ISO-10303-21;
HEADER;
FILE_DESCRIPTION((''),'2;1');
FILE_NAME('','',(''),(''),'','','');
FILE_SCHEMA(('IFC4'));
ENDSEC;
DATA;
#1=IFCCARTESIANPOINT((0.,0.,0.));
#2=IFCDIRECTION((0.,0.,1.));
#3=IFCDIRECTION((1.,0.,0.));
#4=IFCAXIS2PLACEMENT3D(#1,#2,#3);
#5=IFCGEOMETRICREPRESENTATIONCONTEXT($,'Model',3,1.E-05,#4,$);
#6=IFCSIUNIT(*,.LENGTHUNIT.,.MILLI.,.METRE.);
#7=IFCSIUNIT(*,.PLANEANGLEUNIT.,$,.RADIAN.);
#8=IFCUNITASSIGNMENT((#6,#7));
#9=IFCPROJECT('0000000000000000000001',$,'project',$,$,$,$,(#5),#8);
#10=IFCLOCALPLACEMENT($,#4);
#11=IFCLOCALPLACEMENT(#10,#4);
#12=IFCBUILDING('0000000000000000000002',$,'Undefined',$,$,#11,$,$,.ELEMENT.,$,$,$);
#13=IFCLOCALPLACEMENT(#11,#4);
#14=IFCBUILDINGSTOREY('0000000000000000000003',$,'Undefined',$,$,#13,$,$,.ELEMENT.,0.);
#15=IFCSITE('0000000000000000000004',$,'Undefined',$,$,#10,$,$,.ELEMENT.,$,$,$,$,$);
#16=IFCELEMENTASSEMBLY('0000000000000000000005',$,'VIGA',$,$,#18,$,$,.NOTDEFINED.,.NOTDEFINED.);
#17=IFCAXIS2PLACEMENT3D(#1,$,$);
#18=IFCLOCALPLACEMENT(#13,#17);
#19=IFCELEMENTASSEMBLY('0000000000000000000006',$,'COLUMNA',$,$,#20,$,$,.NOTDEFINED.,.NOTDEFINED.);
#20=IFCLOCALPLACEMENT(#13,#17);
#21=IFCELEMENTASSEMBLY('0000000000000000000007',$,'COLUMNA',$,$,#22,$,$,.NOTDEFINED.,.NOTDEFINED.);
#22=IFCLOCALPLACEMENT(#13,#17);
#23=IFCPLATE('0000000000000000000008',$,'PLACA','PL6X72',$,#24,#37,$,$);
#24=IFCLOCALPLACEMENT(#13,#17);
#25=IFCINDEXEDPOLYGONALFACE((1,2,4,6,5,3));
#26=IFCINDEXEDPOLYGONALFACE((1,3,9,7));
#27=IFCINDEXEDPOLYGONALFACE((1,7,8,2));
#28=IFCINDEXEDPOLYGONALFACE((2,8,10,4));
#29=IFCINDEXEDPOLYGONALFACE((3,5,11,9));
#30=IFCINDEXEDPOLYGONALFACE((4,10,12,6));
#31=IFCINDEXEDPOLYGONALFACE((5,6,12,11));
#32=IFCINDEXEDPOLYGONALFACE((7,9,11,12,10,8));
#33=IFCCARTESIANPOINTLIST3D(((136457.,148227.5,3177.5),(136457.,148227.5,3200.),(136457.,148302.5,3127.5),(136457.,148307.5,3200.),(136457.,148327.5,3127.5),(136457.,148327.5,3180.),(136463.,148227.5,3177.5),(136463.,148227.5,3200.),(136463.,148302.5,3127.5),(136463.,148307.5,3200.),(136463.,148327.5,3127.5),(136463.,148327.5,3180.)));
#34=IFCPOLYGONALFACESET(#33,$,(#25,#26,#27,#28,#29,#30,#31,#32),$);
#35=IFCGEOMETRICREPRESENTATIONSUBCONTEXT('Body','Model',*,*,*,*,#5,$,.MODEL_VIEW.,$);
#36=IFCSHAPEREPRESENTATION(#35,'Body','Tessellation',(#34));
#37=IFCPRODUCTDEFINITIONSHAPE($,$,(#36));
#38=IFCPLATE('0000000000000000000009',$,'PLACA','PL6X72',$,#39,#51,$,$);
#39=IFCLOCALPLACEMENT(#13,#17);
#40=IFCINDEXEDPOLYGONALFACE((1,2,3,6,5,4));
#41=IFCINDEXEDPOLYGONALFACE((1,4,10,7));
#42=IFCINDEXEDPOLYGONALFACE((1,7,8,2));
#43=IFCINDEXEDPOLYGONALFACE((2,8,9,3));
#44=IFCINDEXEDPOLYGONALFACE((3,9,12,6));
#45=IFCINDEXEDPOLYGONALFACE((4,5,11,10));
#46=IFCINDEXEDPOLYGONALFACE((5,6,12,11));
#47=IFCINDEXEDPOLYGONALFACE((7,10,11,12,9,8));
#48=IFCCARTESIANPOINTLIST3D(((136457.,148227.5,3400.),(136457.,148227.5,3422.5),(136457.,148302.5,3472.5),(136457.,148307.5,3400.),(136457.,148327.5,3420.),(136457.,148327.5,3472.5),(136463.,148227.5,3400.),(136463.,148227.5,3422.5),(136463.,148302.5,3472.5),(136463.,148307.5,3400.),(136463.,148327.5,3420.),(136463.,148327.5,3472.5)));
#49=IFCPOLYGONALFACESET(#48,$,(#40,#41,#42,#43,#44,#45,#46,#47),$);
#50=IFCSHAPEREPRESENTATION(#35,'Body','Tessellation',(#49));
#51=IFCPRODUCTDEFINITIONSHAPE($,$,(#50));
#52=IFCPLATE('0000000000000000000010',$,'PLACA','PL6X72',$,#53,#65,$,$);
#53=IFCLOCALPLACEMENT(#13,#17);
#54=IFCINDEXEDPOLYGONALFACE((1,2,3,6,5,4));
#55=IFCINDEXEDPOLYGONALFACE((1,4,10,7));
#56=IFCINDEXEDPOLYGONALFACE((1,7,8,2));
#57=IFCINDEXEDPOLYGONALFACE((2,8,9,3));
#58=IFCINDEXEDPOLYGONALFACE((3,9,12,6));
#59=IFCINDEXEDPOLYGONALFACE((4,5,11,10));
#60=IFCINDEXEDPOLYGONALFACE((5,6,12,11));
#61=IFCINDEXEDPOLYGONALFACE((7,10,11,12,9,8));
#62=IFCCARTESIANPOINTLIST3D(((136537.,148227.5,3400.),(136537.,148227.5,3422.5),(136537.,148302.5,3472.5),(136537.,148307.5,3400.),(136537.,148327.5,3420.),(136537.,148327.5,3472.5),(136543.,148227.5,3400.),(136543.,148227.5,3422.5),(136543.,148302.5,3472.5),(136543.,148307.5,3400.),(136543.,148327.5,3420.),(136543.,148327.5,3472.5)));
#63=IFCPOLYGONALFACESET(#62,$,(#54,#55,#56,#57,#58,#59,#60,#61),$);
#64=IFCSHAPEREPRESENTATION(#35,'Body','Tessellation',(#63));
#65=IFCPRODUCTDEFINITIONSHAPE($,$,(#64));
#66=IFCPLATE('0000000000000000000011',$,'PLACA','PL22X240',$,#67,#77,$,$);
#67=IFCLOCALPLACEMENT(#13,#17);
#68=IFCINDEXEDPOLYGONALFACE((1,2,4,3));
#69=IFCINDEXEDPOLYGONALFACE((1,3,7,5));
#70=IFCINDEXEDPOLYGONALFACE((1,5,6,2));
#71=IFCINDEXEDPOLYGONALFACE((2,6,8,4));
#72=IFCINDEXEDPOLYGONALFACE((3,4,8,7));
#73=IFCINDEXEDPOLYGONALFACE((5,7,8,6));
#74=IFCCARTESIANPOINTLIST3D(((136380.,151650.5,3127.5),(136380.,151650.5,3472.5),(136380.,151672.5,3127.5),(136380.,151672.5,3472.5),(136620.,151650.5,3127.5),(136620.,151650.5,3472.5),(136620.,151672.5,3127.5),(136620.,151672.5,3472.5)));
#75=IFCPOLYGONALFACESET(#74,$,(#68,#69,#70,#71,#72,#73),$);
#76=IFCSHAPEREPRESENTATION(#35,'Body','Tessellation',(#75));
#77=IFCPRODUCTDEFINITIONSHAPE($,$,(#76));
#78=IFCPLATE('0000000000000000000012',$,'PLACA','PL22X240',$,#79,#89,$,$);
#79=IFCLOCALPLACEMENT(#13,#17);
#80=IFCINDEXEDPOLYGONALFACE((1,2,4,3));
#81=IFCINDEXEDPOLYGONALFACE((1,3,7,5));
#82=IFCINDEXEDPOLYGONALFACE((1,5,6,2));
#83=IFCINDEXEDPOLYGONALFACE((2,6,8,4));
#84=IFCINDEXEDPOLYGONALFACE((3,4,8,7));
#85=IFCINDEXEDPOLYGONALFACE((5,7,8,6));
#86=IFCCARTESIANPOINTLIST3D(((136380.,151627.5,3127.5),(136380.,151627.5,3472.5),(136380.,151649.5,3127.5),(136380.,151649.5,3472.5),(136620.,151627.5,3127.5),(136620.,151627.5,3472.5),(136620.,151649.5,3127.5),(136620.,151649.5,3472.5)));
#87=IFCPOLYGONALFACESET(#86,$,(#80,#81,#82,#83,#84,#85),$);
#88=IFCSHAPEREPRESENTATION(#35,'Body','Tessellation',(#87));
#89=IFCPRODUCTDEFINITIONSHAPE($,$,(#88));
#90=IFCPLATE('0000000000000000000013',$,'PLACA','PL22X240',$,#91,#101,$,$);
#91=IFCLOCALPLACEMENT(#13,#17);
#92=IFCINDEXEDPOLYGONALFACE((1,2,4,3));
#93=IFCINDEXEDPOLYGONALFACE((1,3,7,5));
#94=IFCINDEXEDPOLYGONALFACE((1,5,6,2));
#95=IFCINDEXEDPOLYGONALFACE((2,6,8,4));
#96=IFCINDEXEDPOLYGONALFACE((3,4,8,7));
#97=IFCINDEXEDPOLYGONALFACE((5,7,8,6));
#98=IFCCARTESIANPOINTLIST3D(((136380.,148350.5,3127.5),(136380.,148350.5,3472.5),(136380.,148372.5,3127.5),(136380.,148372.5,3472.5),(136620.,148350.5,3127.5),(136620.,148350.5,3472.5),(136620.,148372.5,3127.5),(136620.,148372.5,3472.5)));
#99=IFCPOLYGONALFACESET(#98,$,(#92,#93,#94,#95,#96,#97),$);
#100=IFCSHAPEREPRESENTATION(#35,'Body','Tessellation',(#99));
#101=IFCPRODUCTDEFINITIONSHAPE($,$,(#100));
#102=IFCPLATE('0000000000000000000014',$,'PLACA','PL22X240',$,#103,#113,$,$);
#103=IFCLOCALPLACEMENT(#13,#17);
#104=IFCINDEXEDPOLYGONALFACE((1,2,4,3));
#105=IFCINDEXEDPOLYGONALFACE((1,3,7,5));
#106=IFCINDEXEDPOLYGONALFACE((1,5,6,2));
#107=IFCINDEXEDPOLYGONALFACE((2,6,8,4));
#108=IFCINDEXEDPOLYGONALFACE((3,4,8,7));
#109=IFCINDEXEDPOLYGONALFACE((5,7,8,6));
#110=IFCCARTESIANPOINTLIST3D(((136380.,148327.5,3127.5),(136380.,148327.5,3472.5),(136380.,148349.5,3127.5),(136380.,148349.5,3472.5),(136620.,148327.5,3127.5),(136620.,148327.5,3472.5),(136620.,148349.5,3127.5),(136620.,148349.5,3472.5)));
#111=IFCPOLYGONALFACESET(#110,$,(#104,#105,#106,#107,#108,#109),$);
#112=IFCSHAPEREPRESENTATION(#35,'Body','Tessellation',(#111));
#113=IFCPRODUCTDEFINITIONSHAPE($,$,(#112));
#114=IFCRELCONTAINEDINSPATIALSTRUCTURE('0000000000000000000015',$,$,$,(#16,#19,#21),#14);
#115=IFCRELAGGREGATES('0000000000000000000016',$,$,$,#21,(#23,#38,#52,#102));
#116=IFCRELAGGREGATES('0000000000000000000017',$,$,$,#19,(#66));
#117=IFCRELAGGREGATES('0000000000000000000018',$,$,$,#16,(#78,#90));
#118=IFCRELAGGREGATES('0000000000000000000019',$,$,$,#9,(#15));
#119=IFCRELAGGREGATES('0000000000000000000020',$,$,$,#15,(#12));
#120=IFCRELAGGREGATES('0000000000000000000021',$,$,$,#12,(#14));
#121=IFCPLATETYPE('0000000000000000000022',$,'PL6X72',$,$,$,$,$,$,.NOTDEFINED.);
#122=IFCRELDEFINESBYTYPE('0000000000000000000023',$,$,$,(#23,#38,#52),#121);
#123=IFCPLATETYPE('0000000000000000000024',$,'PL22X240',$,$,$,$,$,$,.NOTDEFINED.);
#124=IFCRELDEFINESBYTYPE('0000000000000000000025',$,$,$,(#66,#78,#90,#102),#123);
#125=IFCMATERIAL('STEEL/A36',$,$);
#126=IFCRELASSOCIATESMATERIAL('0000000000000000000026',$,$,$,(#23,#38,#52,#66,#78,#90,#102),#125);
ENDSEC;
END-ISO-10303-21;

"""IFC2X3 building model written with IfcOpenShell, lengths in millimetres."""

from ifc_helpers import new_model, si_unit, frame, origin_with_axes, place, context, subcontext, project, spatial, polyline, outline, extrude, material, type_object, element, aggregate, save


model = new_model("IFC2X3")

# Units and contexts
model_context = context("Model", 3, precision=1e-05, world=origin_with_axes())
body_context = subcontext(model_context, "Body", "Model", "MODEL_VIEW")
ifc_project = project(units=[si_unit("LENGTHUNIT", "METRE", prefix="MILLI"), si_unit("PLANEANGLEUNIT", "RADIAN")], contexts=[model_context])

# Site, building, storey
site_placement = place(None, origin_with_axes())
site = spatial("IfcSite", under=ifc_project, at=site_placement, Name="Undefined", CompositionType="ELEMENT")
building_placement = place(site_placement, origin_with_axes())
building = spatial("IfcBuilding", under=site, at=building_placement, Name="Undefined", CompositionType="ELEMENT")
storey_placement = place(building_placement, origin_with_axes())
storey = spatial("IfcBuildingStorey", under=building, at=storey_placement, Name="Undefined", CompositionType="ELEMENT", Elevation=0.0)

# Element assemblies
assembly_1_placement = place(storey_placement, origin_with_axes())
assembly_1 = element("IfcElementAssembly", 1, at=assembly_1_placement, inside=storey, Name="VIGA", AssemblyPlace="NOTDEFINED", PredefinedType="NOTDEFINED")
ifc_material_1 = material(Name="STEEL/A36")
assembly_2_placement = place(storey_placement, origin_with_axes())
assembly_2 = element("IfcElementAssembly", 2, at=assembly_2_placement, inside=storey, Name="COLUMNA", AssemblyPlace="NOTDEFINED", PredefinedType="NOTDEFINED")

# Element assembly
assembly_3_placement = place(storey_placement, origin_with_axes())
assembly_3 = element("IfcElementAssembly", 3, at=assembly_3_placement, inside=storey, Name="COLUMNA", AssemblyPlace="NOTDEFINED", PredefinedType="NOTDEFINED")

# Plates
plate_type_1 = type_object("IfcPlateType", Name="PL6X72", PredefinedType="NOTDEFINED")
plate_1_placement = place(assembly_3_placement, frame((136460.0, 148327.5, 3127.5), z_axis=(-1.0, 0.0, 0.0), x_axis=(0.0, -1.0, 0.0)))
plate_1 = element("IfcPlate", 4, at=plate_1_placement, type_object=plate_type_1, material=ifc_material_1, Name="PLACA", Description="PL6X72", context=body_context, shape_type="SweptSolid", body=[
    extrude(outline(polyline([(0.0, 0.0), (25.0, 0.0), (100.0, 50.0), (100.0, 72.5), (20.0, 72.5), (0.0, 52.5), (0.0, 0.0)])), frame((0.0, 0.0, -3.0), z_axis=(0.0, 0.0, 1.0), x_axis=(1.0, 0.0, 0.0)), (0.0, 0.0, 1.0), 6.0),
])
plate_2_placement = place(assembly_3_placement, frame((136460.0, 148327.5, 3472.5), z_axis=(1.0, 0.0, 0.0), x_axis=(0.0, -1.0, 0.0)))
plate_2 = element("IfcPlate", 5, at=plate_2_placement, type_object=plate_type_1, material=ifc_material_1, Name="PLACA", Description="PL6X72", context=body_context, shape_type="SweptSolid", body=[
    extrude(outline(polyline([(0.0, 0.0), (25.0, 0.0), (100.0, 50.0), (100.0, 72.5), (20.0, 72.5), (0.0, 52.5), (0.0, 0.0)])), frame((0.0, 0.0, -3.0), z_axis=(0.0, 0.0, 1.0), x_axis=(1.0, 0.0, 0.0)), (0.0, 0.0, 1.0), 6.0),
])
plate_3_placement = place(assembly_3_placement, frame((136540.0, 148327.5, 3472.5), z_axis=(1.0, 0.0, 0.0), x_axis=(0.0, -1.0, 0.0)))
plate_3 = element("IfcPlate", 6, at=plate_3_placement, type_object=plate_type_1, material=ifc_material_1, Name="PLACA", Description="PL6X72", context=body_context, shape_type="SweptSolid", body=[
    extrude(outline(polyline([(0.0, 0.0), (25.0, 0.0), (100.0, 50.0), (100.0, 72.5), (20.0, 72.5), (0.0, 52.5), (0.0, 0.0)])), frame((0.0, 0.0, -3.0), z_axis=(0.0, 0.0, 1.0), x_axis=(1.0, 0.0, 0.0)), (0.0, 0.0, 1.0), 6.0),
])
plate_type_2 = type_object("IfcPlateType", Name="PL22X240", PredefinedType="NOTDEFINED")
plate_4_placement = place(assembly_2_placement, frame((136500.0, 151661.5, 3127.5), z_axis=(0.0, 1.0, 0.0), x_axis=(0.0, 0.0, 1.0)))
plate_4 = element("IfcPlate", 7, at=plate_4_placement, type_object=plate_type_2, material=ifc_material_1, Name="PLACA", Description="PL22X240", context=body_context, shape_type="SweptSolid", body=[
    extrude(outline(polyline([(0.0, -120.0), (0.0, 120.0), (345.0, 120.0), (345.0, -120.0), (0.0, -120.0)])), frame((0.0, 0.0, -11.0), z_axis=(0.0, 0.0, 1.0), x_axis=(1.0, 0.0, 0.0)), (0.0, 0.0, 1.0), 22.0),
])
plate_5_placement = place(assembly_1_placement, frame((136500.0, 151638.5, 3127.5), z_axis=(0.0, 1.0, 0.0), x_axis=(0.0, 0.0, 1.0)))
plate_5 = element("IfcPlate", 8, at=plate_5_placement, type_object=plate_type_2, material=ifc_material_1, Name="PLACA", Description="PL22X240", context=body_context, shape_type="SweptSolid", body=[
    extrude(outline(polyline([(0.0, -120.0), (0.0, 120.0), (345.0, 120.0), (345.0, -120.0), (0.0, -120.0)])), frame((0.0, 0.0, -11.0), z_axis=(0.0, 0.0, 1.0), x_axis=(1.0, 0.0, 0.0)), (0.0, 0.0, 1.0), 22.0),
])
plate_6_placement = place(assembly_1_placement, frame((136500.0, 148361.5, 3127.5), z_axis=(0.0, 1.0, 0.0), x_axis=(0.0, 0.0, 1.0)))
plate_6 = element("IfcPlate", 9, at=plate_6_placement, type_object=plate_type_2, material=ifc_material_1, Name="PLACA", Description="PL22X240", context=body_context, shape_type="SweptSolid", body=[
    extrude(outline(polyline([(0.0, -120.0), (0.0, 120.0), (345.0, 120.0), (345.0, -120.0), (0.0, -120.0)])), frame((0.0, 0.0, -11.0), z_axis=(0.0, 0.0, 1.0), x_axis=(1.0, 0.0, 0.0)), (0.0, 0.0, 1.0), 22.0),
])
plate_7_placement = place(assembly_3_placement, frame((136500.0, 148338.5, 3127.5), z_axis=(0.0, 1.0, 0.0), x_axis=(0.0, 0.0, 1.0)))
plate_7 = element("IfcPlate", 10, at=plate_7_placement, type_object=plate_type_2, material=ifc_material_1, Name="PLACA", Description="PL22X240", context=body_context, shape_type="SweptSolid", body=[
    extrude(outline(polyline([(0.0, -120.0), (0.0, 120.0), (345.0, 120.0), (345.0, -120.0), (0.0, -120.0)])), frame((0.0, 0.0, -11.0), z_axis=(0.0, 0.0, 1.0), x_axis=(1.0, 0.0, 0.0)), (0.0, 0.0, 1.0), 22.0),
])
aggregate(assembly_3, [plate_1, plate_2, plate_3, plate_7])

aggregate(assembly_2, [plate_4])
aggregate(assembly_1, [plate_5, plate_6])

save(model, "model.ifc")
